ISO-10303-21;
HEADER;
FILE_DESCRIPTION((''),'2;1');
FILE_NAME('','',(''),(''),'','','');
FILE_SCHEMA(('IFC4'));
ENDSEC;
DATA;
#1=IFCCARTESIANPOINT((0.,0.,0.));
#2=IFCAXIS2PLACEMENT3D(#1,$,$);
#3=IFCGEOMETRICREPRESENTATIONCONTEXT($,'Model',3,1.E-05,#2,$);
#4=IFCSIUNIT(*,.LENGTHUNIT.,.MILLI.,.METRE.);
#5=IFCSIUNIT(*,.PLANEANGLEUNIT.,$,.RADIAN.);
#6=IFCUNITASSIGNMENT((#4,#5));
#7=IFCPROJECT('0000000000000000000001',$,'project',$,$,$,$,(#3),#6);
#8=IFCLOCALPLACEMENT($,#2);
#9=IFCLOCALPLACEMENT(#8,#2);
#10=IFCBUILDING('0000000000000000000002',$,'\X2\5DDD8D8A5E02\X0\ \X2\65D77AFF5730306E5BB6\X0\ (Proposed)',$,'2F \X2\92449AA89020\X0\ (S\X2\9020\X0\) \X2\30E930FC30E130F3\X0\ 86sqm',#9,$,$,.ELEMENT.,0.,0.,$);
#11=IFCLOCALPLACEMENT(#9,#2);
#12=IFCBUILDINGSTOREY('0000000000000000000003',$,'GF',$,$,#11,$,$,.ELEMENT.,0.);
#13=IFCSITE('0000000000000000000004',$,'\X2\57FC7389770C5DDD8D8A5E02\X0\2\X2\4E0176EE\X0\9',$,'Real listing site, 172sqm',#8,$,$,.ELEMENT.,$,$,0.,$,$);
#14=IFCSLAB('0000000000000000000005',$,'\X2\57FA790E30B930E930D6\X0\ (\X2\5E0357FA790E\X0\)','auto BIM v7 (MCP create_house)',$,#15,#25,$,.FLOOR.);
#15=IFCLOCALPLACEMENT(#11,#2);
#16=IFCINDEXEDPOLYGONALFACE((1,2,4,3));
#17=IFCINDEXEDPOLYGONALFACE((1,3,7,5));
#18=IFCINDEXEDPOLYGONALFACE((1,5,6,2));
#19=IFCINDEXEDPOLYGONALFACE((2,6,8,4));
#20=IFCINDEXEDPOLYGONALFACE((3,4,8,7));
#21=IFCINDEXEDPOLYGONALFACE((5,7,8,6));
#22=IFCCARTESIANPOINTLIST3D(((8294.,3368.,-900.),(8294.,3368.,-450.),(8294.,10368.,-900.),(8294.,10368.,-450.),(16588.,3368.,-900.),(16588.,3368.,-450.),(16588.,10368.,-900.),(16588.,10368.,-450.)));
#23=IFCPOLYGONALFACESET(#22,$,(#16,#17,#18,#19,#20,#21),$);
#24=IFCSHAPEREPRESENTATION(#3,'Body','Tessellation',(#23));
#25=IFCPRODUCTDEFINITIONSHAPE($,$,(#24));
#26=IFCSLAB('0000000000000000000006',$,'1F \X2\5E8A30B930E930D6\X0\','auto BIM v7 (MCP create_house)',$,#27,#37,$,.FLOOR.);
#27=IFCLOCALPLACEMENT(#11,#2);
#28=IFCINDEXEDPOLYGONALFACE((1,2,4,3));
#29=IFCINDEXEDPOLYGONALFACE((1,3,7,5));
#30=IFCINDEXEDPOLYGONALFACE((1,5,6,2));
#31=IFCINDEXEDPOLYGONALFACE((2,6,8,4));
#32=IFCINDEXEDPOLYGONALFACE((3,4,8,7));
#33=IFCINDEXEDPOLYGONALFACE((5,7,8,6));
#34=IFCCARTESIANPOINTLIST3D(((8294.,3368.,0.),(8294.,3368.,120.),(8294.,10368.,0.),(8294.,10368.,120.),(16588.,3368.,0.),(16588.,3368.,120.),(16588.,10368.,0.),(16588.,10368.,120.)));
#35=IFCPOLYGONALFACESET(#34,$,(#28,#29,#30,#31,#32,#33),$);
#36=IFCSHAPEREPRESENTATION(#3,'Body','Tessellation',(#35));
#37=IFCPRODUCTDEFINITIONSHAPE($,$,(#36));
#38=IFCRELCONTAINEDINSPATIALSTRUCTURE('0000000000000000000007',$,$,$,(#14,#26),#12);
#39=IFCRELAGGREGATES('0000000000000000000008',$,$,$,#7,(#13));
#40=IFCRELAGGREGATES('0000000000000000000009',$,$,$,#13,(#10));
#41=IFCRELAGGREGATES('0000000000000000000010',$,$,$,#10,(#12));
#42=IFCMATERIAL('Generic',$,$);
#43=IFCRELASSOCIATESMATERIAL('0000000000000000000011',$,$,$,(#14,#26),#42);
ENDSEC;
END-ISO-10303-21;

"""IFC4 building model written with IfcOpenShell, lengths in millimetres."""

from ifc_helpers import new_model, si_unit, frame, frame_2d, origin, place, context, project, spatial, rectangle, extrude, material, element, save


model = new_model("IFC4")

# Units and contexts
model_context = context("Model", 3, precision=1e-05, world=origin())
ifc_project = project(units=[si_unit("LENGTHUNIT", "METRE", prefix="MILLI"), si_unit("PLANEANGLEUNIT", "RADIAN")], contexts=[model_context])

# Site, building, storey
site_placement = place(None, origin())
site = spatial("IfcSite", under=ifc_project, at=site_placement, Name="埼玉県川越市2丁目9", ObjectType="Real listing site, 172sqm", CompositionType="ELEMENT", RefElevation=0.0)
building_placement = place(site_placement, origin())
building = spatial("IfcBuilding", under=site, at=building_placement, Name="川越市 旗竿地の家 (Proposed)", ObjectType="2F 鉄骨造 (S造) ラーメン 86sqm", CompositionType="ELEMENT", ElevationOfRefHeight=0.0, ElevationOfTerrain=0.0)
storey_placement = place(building_placement, origin())
storey = spatial("IfcBuildingStorey", under=building, at=storey_placement, Name="GF", CompositionType="ELEMENT", Elevation=0.0)

# Slabs
ifc_material = material(Name="Generic")
slab_1_placement = place(storey_placement, frame((4147.0, 1684.0, -450.0)))
element("IfcSlab", 1, at=slab_1_placement, inside=storey, material=ifc_material, Name="基礎スラブ (布基礎)", Description="auto BIM v7 (MCP create_house)", PredefinedType="FLOOR", context=model_context, shape_type="SweptSolid", body=[
    extrude(rectangle(XDim=8294.0, YDim=7000.0, at=frame_2d((4147.0, 3500.0))), frame((4147.0, 1684.0, -450.0)), (0.0, 0.0, 1.0), 450.0),
])
slab_2_placement = place(storey_placement, frame((4147.0, 1684.0, 0.0)))
element("IfcSlab", 2, at=slab_2_placement, inside=storey, material=ifc_material, Name="1F 床スラブ", Description="auto BIM v7 (MCP create_house)", PredefinedType="FLOOR", context=model_context, shape_type="SweptSolid", body=[
    extrude(rectangle(XDim=8294.0, YDim=7000.0, at=frame_2d((4147.0, 3500.0))), frame((4147.0, 1684.0, 0.0)), (0.0, 0.0, 1.0), 120.0),
])

save(model, "model.ifc")
